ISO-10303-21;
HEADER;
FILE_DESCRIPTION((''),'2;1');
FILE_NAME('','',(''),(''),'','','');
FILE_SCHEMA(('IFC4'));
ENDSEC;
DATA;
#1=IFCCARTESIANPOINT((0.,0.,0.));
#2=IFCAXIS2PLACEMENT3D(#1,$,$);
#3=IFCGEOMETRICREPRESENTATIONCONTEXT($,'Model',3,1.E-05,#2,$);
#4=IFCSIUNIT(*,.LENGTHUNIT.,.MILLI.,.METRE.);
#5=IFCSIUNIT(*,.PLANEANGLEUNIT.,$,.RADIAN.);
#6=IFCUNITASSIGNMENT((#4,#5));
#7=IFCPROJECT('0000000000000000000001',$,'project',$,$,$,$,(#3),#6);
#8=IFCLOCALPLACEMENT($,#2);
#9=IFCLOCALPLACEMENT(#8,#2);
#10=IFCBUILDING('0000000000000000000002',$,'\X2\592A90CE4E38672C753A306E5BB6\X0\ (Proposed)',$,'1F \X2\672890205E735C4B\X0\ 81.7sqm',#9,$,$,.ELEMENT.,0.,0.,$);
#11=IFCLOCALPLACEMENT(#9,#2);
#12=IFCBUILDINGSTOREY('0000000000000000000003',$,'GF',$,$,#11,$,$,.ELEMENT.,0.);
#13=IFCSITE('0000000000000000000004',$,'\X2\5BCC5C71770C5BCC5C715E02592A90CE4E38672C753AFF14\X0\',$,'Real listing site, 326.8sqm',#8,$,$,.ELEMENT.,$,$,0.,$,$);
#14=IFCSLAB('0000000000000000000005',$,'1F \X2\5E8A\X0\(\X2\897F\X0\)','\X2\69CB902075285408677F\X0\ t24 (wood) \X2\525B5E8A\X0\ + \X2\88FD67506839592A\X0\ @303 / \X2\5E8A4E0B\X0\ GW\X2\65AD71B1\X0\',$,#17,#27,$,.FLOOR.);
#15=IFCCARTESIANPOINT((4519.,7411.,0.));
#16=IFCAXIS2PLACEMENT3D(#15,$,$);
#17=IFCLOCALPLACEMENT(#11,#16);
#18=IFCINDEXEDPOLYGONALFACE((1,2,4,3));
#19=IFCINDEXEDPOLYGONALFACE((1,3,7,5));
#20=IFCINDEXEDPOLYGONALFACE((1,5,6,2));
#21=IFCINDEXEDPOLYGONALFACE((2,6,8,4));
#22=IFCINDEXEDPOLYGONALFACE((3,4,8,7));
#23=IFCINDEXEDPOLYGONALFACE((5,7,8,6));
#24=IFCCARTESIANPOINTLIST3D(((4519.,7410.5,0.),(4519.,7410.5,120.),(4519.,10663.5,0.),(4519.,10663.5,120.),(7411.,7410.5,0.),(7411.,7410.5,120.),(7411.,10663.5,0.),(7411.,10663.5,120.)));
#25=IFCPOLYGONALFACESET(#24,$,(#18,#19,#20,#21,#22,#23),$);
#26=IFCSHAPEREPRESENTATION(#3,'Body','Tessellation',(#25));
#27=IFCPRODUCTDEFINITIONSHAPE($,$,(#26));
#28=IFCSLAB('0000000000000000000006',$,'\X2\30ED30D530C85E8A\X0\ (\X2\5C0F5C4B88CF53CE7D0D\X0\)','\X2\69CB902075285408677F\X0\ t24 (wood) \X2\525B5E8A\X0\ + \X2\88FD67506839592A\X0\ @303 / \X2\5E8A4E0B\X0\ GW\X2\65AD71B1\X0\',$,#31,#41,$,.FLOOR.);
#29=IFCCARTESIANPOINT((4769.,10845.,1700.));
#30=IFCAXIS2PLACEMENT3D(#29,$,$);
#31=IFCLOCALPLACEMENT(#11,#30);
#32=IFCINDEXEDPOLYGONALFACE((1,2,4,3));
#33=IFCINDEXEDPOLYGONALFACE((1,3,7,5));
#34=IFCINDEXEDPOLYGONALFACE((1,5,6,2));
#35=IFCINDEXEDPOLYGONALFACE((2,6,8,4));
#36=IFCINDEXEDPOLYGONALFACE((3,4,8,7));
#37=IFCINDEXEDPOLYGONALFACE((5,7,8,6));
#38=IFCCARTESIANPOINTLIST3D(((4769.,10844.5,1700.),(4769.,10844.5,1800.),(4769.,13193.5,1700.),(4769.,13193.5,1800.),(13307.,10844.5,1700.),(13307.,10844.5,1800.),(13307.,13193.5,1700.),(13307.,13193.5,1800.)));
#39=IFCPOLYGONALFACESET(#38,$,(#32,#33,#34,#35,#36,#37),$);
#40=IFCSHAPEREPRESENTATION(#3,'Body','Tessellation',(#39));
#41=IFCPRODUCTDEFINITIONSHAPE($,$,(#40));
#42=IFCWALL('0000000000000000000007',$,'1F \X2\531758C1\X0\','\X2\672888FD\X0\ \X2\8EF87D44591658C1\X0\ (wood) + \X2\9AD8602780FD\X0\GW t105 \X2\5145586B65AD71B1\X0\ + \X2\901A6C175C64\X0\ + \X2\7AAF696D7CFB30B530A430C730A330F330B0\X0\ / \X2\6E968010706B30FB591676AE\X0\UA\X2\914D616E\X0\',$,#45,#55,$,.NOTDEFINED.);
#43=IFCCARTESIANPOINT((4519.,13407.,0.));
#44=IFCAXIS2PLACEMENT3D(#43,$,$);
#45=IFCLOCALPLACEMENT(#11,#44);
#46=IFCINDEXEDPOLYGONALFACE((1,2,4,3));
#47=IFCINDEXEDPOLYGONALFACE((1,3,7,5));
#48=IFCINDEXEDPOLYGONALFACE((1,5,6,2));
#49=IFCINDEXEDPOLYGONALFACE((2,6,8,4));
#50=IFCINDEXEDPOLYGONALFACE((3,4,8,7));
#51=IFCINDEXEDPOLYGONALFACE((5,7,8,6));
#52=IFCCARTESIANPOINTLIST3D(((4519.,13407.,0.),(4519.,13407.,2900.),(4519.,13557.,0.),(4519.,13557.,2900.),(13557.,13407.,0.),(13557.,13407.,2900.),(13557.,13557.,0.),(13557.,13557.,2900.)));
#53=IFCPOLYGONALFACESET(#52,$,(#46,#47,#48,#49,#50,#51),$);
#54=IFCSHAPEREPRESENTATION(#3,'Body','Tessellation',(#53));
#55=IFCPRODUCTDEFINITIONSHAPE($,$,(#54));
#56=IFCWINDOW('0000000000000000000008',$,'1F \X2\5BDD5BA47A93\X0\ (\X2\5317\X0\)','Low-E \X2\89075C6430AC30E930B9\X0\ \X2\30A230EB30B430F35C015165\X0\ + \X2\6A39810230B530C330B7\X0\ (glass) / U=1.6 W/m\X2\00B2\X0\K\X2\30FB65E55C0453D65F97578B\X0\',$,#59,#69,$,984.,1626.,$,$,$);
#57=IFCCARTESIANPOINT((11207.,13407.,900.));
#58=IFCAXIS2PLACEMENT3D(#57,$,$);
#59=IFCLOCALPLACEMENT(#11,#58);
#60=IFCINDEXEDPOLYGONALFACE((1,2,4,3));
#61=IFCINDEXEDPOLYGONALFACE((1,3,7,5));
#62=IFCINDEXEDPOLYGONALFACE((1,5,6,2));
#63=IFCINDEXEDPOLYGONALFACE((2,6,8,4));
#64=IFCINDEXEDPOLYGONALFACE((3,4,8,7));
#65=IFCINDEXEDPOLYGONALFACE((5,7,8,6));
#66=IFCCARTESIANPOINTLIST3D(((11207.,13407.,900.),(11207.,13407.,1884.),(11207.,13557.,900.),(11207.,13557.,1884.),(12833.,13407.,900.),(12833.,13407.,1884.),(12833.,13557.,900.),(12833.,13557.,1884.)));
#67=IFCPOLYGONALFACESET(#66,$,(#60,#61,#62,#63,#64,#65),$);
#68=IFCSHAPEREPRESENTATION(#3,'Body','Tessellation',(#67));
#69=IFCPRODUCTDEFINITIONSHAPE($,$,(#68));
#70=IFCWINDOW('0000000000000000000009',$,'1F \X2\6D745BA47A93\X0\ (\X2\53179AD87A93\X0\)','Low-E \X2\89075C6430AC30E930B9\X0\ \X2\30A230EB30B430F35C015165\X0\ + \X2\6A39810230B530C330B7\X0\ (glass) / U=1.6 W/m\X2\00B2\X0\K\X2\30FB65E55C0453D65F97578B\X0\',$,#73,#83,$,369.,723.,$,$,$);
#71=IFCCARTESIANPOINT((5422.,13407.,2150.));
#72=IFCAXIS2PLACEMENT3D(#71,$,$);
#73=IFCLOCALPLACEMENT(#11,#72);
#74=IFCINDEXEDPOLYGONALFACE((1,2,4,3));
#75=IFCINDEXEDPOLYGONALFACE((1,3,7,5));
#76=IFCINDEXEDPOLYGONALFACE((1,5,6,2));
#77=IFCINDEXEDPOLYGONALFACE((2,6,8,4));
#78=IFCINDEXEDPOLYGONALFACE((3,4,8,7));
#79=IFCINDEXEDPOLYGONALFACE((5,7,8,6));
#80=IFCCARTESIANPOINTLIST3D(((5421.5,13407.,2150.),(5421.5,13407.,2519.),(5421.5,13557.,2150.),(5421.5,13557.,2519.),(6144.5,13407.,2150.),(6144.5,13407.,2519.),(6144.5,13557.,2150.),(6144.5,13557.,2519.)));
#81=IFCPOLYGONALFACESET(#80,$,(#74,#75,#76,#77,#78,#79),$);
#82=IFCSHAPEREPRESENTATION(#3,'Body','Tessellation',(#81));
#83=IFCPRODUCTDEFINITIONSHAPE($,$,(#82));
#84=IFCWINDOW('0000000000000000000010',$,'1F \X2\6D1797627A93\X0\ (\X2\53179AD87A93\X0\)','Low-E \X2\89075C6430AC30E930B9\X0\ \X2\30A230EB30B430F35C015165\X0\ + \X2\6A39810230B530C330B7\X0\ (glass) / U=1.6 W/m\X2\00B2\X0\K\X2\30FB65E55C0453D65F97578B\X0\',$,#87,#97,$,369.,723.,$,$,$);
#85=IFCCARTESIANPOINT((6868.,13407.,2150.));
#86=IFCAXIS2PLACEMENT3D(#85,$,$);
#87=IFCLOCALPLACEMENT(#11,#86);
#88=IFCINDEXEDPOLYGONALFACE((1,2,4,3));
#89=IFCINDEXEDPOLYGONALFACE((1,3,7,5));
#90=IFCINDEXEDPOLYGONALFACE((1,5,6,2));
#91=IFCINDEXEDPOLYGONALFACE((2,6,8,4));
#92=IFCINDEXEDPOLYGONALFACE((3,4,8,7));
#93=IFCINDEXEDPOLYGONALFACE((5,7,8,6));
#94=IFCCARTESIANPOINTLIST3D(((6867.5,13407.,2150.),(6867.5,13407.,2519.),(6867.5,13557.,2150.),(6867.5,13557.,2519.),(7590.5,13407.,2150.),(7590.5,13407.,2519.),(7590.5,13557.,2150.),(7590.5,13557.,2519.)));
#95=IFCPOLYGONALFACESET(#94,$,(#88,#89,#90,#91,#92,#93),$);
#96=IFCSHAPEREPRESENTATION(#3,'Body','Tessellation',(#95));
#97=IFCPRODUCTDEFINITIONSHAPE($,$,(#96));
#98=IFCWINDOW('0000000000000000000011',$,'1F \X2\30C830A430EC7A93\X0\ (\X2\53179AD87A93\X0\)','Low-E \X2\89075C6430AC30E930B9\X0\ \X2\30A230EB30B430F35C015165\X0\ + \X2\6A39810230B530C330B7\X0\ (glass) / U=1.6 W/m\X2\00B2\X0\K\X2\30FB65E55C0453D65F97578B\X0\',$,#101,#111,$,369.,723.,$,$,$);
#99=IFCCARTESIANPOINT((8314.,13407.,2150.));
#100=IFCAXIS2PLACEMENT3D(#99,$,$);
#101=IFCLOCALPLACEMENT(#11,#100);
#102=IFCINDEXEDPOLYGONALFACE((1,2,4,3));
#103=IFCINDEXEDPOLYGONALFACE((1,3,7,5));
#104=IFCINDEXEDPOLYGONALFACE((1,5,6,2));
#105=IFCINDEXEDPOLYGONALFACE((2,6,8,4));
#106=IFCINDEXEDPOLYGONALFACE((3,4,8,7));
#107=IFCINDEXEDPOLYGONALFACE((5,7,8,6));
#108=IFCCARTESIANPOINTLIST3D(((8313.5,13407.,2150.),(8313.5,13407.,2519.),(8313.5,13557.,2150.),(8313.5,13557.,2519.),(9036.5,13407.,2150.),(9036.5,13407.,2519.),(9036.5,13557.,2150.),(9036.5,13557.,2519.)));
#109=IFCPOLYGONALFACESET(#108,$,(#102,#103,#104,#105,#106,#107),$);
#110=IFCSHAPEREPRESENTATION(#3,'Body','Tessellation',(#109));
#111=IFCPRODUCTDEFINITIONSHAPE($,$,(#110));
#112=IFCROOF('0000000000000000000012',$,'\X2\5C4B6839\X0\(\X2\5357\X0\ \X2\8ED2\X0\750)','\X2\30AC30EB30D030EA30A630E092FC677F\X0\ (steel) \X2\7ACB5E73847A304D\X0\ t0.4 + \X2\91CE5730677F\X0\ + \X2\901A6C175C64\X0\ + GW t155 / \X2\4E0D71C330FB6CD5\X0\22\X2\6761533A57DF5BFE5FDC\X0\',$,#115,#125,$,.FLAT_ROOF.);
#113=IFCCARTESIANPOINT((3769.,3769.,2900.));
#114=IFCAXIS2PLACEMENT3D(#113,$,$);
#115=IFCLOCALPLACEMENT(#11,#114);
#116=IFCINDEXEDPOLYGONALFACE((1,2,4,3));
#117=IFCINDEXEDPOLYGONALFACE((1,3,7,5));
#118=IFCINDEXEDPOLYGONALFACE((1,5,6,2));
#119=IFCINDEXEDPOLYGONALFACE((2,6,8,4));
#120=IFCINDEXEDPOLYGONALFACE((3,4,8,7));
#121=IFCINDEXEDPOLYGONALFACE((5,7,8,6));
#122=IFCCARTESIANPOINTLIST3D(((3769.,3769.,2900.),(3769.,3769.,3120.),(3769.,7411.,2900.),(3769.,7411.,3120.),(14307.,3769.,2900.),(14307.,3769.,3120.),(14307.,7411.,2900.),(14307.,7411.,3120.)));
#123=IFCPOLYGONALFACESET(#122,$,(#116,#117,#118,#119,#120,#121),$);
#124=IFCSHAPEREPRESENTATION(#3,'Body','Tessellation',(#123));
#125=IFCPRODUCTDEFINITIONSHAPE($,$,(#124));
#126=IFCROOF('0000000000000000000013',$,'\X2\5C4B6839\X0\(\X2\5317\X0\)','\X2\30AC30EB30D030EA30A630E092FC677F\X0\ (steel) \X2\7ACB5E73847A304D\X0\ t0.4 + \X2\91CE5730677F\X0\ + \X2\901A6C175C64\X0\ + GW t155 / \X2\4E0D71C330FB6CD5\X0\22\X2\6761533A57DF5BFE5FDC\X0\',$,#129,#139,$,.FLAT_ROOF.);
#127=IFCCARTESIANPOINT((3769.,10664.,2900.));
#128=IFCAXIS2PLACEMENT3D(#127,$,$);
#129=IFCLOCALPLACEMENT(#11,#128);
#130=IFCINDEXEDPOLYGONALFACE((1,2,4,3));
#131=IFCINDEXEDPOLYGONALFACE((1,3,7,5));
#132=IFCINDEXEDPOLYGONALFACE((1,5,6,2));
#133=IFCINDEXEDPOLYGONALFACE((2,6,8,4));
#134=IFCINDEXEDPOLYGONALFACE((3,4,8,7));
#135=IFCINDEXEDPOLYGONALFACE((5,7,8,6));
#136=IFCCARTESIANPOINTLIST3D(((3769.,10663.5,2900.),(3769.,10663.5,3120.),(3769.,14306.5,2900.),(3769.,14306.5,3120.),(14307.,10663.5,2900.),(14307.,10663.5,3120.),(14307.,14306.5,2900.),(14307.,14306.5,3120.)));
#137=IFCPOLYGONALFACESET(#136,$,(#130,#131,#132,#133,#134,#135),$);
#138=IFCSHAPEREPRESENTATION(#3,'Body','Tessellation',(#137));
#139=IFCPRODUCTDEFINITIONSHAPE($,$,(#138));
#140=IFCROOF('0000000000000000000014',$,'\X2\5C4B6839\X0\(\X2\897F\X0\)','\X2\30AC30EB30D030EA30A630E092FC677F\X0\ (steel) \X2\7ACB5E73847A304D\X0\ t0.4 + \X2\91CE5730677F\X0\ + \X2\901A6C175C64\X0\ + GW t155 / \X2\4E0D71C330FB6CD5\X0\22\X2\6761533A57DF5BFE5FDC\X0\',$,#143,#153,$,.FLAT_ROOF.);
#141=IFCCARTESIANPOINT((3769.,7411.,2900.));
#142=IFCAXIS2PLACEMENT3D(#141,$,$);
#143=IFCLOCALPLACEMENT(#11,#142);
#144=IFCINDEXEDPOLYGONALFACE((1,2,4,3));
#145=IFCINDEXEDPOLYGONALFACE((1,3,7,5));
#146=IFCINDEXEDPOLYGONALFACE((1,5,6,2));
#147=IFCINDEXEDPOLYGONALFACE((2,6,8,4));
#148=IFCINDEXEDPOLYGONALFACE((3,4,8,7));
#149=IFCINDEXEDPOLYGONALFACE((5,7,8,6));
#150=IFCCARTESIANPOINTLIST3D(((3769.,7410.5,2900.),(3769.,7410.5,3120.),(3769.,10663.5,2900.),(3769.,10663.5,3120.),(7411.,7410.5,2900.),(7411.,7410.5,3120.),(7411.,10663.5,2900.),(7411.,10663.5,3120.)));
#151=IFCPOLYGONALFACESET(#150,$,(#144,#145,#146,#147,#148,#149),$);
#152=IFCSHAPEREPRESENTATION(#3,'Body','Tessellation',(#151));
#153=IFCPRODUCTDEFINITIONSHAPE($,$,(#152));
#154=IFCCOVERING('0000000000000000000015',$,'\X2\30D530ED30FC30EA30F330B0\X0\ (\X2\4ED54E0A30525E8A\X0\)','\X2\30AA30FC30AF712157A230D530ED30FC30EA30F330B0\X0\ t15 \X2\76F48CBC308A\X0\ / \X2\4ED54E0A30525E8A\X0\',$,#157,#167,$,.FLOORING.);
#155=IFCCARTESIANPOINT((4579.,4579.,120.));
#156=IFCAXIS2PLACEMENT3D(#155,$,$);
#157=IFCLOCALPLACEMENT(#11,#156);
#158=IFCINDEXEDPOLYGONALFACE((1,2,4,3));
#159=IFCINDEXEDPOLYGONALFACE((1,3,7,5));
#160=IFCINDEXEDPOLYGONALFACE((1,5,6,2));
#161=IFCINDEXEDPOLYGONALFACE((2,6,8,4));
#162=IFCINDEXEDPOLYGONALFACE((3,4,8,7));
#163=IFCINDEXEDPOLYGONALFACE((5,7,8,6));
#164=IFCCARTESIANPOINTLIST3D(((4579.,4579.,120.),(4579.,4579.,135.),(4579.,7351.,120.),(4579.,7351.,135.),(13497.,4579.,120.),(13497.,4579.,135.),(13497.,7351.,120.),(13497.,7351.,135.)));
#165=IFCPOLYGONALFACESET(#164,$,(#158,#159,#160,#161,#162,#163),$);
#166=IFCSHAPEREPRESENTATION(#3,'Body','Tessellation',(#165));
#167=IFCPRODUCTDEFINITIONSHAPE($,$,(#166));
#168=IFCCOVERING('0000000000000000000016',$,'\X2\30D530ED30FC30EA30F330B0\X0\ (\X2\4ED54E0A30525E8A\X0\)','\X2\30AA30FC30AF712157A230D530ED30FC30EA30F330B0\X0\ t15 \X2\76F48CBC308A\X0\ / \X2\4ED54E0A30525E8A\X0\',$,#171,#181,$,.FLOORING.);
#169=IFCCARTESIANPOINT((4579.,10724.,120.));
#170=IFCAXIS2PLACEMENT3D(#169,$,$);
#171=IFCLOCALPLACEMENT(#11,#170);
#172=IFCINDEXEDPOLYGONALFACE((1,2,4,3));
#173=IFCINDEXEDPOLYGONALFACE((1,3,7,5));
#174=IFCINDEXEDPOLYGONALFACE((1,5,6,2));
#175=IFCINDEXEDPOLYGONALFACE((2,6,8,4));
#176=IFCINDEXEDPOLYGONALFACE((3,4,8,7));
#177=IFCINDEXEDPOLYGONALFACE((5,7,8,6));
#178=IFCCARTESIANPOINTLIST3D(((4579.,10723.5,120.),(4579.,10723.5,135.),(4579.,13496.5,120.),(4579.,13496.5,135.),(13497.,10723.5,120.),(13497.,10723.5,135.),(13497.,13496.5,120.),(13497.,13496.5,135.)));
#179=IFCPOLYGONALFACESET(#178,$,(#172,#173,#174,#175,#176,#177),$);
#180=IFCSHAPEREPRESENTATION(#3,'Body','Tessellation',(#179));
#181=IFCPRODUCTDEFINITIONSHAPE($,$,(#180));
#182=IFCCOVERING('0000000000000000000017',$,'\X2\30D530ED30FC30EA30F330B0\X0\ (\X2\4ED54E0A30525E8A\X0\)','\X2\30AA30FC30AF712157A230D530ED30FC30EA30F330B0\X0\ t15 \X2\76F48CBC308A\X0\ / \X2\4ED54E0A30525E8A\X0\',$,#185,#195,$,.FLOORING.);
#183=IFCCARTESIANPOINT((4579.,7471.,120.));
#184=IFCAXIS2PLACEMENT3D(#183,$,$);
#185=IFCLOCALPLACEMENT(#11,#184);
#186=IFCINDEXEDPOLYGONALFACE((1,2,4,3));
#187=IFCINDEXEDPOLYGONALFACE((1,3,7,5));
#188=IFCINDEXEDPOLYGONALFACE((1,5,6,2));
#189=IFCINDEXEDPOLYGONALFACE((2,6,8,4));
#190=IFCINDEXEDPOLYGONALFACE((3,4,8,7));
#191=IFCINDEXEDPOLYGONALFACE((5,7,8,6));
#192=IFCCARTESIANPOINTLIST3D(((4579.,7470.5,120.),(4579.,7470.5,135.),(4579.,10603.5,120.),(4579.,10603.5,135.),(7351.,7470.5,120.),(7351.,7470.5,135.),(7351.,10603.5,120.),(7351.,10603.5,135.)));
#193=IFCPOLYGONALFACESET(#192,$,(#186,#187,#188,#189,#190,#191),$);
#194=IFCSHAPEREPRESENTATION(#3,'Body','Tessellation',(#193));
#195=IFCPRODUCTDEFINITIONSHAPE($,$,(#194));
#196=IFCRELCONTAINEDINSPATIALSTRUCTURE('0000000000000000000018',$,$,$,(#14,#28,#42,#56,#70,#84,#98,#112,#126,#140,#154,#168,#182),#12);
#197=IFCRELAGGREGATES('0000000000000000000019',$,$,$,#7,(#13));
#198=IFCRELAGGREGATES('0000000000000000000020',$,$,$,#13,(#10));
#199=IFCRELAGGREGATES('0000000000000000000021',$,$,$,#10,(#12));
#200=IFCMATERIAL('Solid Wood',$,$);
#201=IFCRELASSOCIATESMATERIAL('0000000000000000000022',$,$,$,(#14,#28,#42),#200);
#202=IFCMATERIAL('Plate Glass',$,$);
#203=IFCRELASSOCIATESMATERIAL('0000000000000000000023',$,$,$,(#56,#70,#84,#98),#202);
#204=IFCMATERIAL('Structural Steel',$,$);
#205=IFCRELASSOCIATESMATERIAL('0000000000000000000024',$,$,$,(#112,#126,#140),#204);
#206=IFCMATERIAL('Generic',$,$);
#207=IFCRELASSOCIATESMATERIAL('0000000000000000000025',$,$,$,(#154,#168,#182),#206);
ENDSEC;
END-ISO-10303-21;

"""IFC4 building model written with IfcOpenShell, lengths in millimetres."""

from ifc_helpers import new_model, si_unit, frame, frame_2d, origin, place, context, project, spatial, rectangle, extrude, material, element, fill, save


model = new_model("IFC4")

# Units and contexts
model_context = context("Model", 3, precision=1e-05, world=origin())
ifc_project = project(units=[si_unit("LENGTHUNIT", "METRE", prefix="MILLI"), si_unit("PLANEANGLEUNIT", "RADIAN")], contexts=[model_context])

# Site, building, storey
site_placement = place(None, origin())
site = spatial("IfcSite", under=ifc_project, at=site_placement, Name="富山県富山市太郎丸本町４", ObjectType="Real listing site, 326.8sqm", CompositionType="ELEMENT", RefElevation=0.0)
building_placement = place(site_placement, origin())
building = spatial("IfcBuilding", under=site, at=building_placement, Name="太郎丸本町の家 (Proposed)", ObjectType="1F 木造平屋 81.7sqm", CompositionType="ELEMENT", ElevationOfRefHeight=0.0, ElevationOfTerrain=0.0)
storey_placement = place(building_placement, origin())
storey = spatial("IfcBuildingStorey", under=building, at=storey_placement, Name="GF", CompositionType="ELEMENT", Elevation=0.0)

# Slabs
ifc_material_1 = material(Name="Solid Wood")
slab_1_placement = place(storey_placement, frame((4519.0, 7411.0, 0.0)))
element("IfcSlab", 1, at=slab_1_placement, inside=storey, material=ifc_material_1, Name="1F 床(西)", Description="構造用合板 t24 (wood) 剛床 + 製材根太 @303 / 床下 GW断熱", PredefinedType="FLOOR", context=model_context, shape_type="SweptSolid", body=[
    extrude(rectangle(XDim=2892.0, YDim=3253.0, at=frame_2d((1446.0, 1626.0))), frame((4519.0, 7411.0, 0.0)), (0.0, 0.0, 1.0), 120.0),
])
slab_2_placement = place(storey_placement, frame((4769.0, 10845.0, 1700.0)))
element("IfcSlab", 2, at=slab_2_placement, inside=storey, material=ifc_material_1, Name="ロフト床 (小屋裏収納)", Description="構造用合板 t24 (wood) 剛床 + 製材根太 @303 / 床下 GW断熱", PredefinedType="FLOOR", context=model_context, shape_type="SweptSolid", body=[
    extrude(rectangle(XDim=8538.0, YDim=2349.0, at=frame_2d((4269.0, 1174.0))), frame((4769.0, 10845.0, 1700.0)), (0.0, 0.0, 1.0), 100.0),
])

# Shared definitions
ifc_material_2 = material(Name="Plate Glass")

# Wall, openings, windows
wall_1_placement = place(storey_placement, frame((4519.0, 13407.0, 0.0)))
wall_1 = element("IfcWall", 3, at=wall_1_placement, inside=storey, material=ifc_material_1, Name="1F 北壁", Description="木製 軸組外壁 (wood) + 高性能GW t105 充填断熱 + 通気層 + 窯業系サイディング / 準耐火・外皮UA配慮", PredefinedType="NOTDEFINED", context=model_context, shape_type="SweptSolid", body=[
    extrude(rectangle(XDim=9038.0, YDim=150.0, at=frame_2d((4519.0, 75.0))), frame((4519.0, 13407.0, 0.0)), (0.0, 0.0, 1.0), 2900.0),
])
opening_1_placement = place(storey_placement, frame((11207.0, 13407.0, 900.0)))
opening_1 = element("IfcOpeningElement", 4, at=opening_1_placement, cuts=wall_1, PredefinedType="NOTDEFINED", context=model_context, shape_type="SweptSolid", body=[
    extrude(rectangle(XDim=1626.0, YDim=150.0, at=frame_2d((813.0, 75.0))), frame((11207.0, 13407.0, 900.0)), (0.0, 0.0, 1.0), 984.0),
])
opening_2_placement = place(storey_placement, frame((5422.0, 13407.0, 2150.0)))
opening_2 = element("IfcOpeningElement", 5, at=opening_2_placement, cuts=wall_1, PredefinedType="NOTDEFINED", context=model_context, shape_type="SweptSolid", body=[
    extrude(rectangle(XDim=723.0, YDim=150.0, at=frame_2d((361.0, 75.0))), frame((5422.0, 13407.0, 2150.0)), (0.0, 0.0, 1.0), 369.0),
])
opening_3_placement = place(storey_placement, frame((6868.0, 13407.0, 2150.0)))
opening_3 = element("IfcOpeningElement", 6, at=opening_3_placement, cuts=wall_1, PredefinedType="NOTDEFINED", context=model_context, shape_type="SweptSolid", body=[
    extrude(rectangle(XDim=723.0, YDim=150.0, at=frame_2d((361.0, 75.0))), frame((6868.0, 13407.0, 2150.0)), (0.0, 0.0, 1.0), 369.0),
])
opening_4_placement = place(storey_placement, frame((8314.0, 13407.0, 2150.0)))
opening_4 = element("IfcOpeningElement", 7, at=opening_4_placement, cuts=wall_1, PredefinedType="NOTDEFINED", context=model_context, shape_type="SweptSolid", body=[
    extrude(rectangle(XDim=723.0, YDim=150.0, at=frame_2d((361.0, 75.0))), frame((8314.0, 13407.0, 2150.0)), (0.0, 0.0, 1.0), 369.0),
])
window_1_placement = place(storey_placement, frame((11207.0, 13407.0, 900.0)))
window_1 = element("IfcWindow", 8, at=window_1_placement, inside=storey, material=ifc_material_2, Name="1F 寝室窓 (北)", Description="Low-E 複層ガラス アルゴン封入 + 樹脂サッシ (glass) / U=1.6 W/m²K・日射取得型", OverallHeight=984.0, OverallWidth=1626.0, context=model_context, shape_type="SweptSolid", body=[
    extrude(rectangle(XDim=1626.0, YDim=150.0, at=frame_2d((813.0, 75.0))), frame((11207.0, 13407.0, 900.0)), (0.0, 0.0, 1.0), 984.0),
])
fill(opening_1, window_1)
window_2_placement = place(storey_placement, frame((5422.0, 13407.0, 2150.0)))
window_2 = element("IfcWindow", 9, at=window_2_placement, inside=storey, material=ifc_material_2, Name="1F 浴室窓 (北高窓)", Description="Low-E 複層ガラス アルゴン封入 + 樹脂サッシ (glass) / U=1.6 W/m²K・日射取得型", OverallHeight=369.0, OverallWidth=723.0, context=model_context, shape_type="SweptSolid", body=[
    extrude(rectangle(XDim=723.0, YDim=150.0, at=frame_2d((361.0, 75.0))), frame((5422.0, 13407.0, 2150.0)), (0.0, 0.0, 1.0), 369.0),
])
fill(opening_2, window_2)
window_3_placement = place(storey_placement, frame((6868.0, 13407.0, 2150.0)))
window_3 = element("IfcWindow", 10, at=window_3_placement, inside=storey, material=ifc_material_2, Name="1F 洗面窓 (北高窓)", Description="Low-E 複層ガラス アルゴン封入 + 樹脂サッシ (glass) / U=1.6 W/m²K・日射取得型", OverallHeight=369.0, OverallWidth=723.0, context=model_context, shape_type="SweptSolid", body=[
    extrude(rectangle(XDim=723.0, YDim=150.0, at=frame_2d((361.0, 75.0))), frame((6868.0, 13407.0, 2150.0)), (0.0, 0.0, 1.0), 369.0),
])
fill(opening_3, window_3)
window_4_placement = place(storey_placement, frame((8314.0, 13407.0, 2150.0)))
window_4 = element("IfcWindow", 11, at=window_4_placement, inside=storey, material=ifc_material_2, Name="1F トイレ窓 (北高窓)", Description="Low-E 複層ガラス アルゴン封入 + 樹脂サッシ (glass) / U=1.6 W/m²K・日射取得型", OverallHeight=369.0, OverallWidth=723.0, context=model_context, shape_type="SweptSolid", body=[
    extrude(rectangle(XDim=723.0, YDim=150.0, at=frame_2d((361.0, 75.0))), frame((8314.0, 13407.0, 2150.0)), (0.0, 0.0, 1.0), 369.0),
])
fill(opening_4, window_4)

# Roofs
ifc_material_3 = material(Name="Structural Steel")
roof_1_placement = place(storey_placement, frame((3769.0, 3769.0, 2900.0)))
element("IfcRoof", 12, at=roof_1_placement, inside=storey, material=ifc_material_3, Name="屋根(南 軒750)", Description="ガルバリウム鋼板 (steel) 立平葺き t0.4 + 野地板 + 通気層 + GW t155 / 不燃・法22条区域対応", PredefinedType="FLAT_ROOF", context=model_context, shape_type="SweptSolid", body=[
    extrude(rectangle(XDim=10538.0, YDim=3642.0, at=frame_2d((5269.0, 1821.0))), frame((3769.0, 3769.0, 2900.0)), (0.0, 0.0, 1.0), 220.0),
])
roof_2_placement = place(storey_placement, frame((3769.0, 10664.0, 2900.0)))
element("IfcRoof", 13, at=roof_2_placement, inside=storey, material=ifc_material_3, Name="屋根(北)", Description="ガルバリウム鋼板 (steel) 立平葺き t0.4 + 野地板 + 通気層 + GW t155 / 不燃・法22条区域対応", PredefinedType="FLAT_ROOF", context=model_context, shape_type="SweptSolid", body=[
    extrude(rectangle(XDim=10538.0, YDim=3643.0, at=frame_2d((5269.0, 1821.0))), frame((3769.0, 10664.0, 2900.0)), (0.0, 0.0, 1.0), 220.0),
])
roof_3_placement = place(storey_placement, frame((3769.0, 7411.0, 2900.0)))
element("IfcRoof", 14, at=roof_3_placement, inside=storey, material=ifc_material_3, Name="屋根(西)", Description="ガルバリウム鋼板 (steel) 立平葺き t0.4 + 野地板 + 通気層 + GW t155 / 不燃・法22条区域対応", PredefinedType="FLAT_ROOF", context=model_context, shape_type="SweptSolid", body=[
    extrude(rectangle(XDim=3642.0, YDim=3253.0, at=frame_2d((1821.0, 1626.0))), frame((3769.0, 7411.0, 2900.0)), (0.0, 0.0, 1.0), 220.0),
])

# Coverings
ifc_material_4 = material(Name="Generic")
covering_1_placement = place(storey_placement, frame((4579.0, 4579.0, 120.0)))
element("IfcCovering", 15, at=covering_1_placement, inside=storey, material=ifc_material_4, Name="フローリング (仕上げ床)", Description="オーク無垢フローリング t15 直貼り / 仕上げ床", PredefinedType="FLOORING", context=model_context, shape_type="SweptSolid", body=[
    extrude(rectangle(XDim=8918.0, YDim=2772.0, at=frame_2d((4459.0, 1386.0))), frame((4579.0, 4579.0, 120.0)), (0.0, 0.0, 1.0), 15.0),
])
covering_2_placement = place(storey_placement, frame((4579.0, 10724.0, 120.0)))
element("IfcCovering", 16, at=covering_2_placement, inside=storey, material=ifc_material_4, Name="フローリング (仕上げ床)", Description="オーク無垢フローリング t15 直貼り / 仕上げ床", PredefinedType="FLOORING", context=model_context, shape_type="SweptSolid", body=[
    extrude(rectangle(XDim=8918.0, YDim=2773.0, at=frame_2d((4459.0, 1386.0))), frame((4579.0, 10724.0, 120.0)), (0.0, 0.0, 1.0), 15.0),
])
covering_3_placement = place(storey_placement, frame((4579.0, 7471.0, 120.0)))
element("IfcCovering", 17, at=covering_3_placement, inside=storey, material=ifc_material_4, Name="フローリング (仕上げ床)", Description="オーク無垢フローリング t15 直貼り / 仕上げ床", PredefinedType="FLOORING", context=model_context, shape_type="SweptSolid", body=[
    extrude(rectangle(XDim=2772.0, YDim=3133.0, at=frame_2d((1386.0, 1566.0))), frame((4579.0, 7471.0, 120.0)), (0.0, 0.0, 1.0), 15.0),
])

save(model, "model.ifc")
